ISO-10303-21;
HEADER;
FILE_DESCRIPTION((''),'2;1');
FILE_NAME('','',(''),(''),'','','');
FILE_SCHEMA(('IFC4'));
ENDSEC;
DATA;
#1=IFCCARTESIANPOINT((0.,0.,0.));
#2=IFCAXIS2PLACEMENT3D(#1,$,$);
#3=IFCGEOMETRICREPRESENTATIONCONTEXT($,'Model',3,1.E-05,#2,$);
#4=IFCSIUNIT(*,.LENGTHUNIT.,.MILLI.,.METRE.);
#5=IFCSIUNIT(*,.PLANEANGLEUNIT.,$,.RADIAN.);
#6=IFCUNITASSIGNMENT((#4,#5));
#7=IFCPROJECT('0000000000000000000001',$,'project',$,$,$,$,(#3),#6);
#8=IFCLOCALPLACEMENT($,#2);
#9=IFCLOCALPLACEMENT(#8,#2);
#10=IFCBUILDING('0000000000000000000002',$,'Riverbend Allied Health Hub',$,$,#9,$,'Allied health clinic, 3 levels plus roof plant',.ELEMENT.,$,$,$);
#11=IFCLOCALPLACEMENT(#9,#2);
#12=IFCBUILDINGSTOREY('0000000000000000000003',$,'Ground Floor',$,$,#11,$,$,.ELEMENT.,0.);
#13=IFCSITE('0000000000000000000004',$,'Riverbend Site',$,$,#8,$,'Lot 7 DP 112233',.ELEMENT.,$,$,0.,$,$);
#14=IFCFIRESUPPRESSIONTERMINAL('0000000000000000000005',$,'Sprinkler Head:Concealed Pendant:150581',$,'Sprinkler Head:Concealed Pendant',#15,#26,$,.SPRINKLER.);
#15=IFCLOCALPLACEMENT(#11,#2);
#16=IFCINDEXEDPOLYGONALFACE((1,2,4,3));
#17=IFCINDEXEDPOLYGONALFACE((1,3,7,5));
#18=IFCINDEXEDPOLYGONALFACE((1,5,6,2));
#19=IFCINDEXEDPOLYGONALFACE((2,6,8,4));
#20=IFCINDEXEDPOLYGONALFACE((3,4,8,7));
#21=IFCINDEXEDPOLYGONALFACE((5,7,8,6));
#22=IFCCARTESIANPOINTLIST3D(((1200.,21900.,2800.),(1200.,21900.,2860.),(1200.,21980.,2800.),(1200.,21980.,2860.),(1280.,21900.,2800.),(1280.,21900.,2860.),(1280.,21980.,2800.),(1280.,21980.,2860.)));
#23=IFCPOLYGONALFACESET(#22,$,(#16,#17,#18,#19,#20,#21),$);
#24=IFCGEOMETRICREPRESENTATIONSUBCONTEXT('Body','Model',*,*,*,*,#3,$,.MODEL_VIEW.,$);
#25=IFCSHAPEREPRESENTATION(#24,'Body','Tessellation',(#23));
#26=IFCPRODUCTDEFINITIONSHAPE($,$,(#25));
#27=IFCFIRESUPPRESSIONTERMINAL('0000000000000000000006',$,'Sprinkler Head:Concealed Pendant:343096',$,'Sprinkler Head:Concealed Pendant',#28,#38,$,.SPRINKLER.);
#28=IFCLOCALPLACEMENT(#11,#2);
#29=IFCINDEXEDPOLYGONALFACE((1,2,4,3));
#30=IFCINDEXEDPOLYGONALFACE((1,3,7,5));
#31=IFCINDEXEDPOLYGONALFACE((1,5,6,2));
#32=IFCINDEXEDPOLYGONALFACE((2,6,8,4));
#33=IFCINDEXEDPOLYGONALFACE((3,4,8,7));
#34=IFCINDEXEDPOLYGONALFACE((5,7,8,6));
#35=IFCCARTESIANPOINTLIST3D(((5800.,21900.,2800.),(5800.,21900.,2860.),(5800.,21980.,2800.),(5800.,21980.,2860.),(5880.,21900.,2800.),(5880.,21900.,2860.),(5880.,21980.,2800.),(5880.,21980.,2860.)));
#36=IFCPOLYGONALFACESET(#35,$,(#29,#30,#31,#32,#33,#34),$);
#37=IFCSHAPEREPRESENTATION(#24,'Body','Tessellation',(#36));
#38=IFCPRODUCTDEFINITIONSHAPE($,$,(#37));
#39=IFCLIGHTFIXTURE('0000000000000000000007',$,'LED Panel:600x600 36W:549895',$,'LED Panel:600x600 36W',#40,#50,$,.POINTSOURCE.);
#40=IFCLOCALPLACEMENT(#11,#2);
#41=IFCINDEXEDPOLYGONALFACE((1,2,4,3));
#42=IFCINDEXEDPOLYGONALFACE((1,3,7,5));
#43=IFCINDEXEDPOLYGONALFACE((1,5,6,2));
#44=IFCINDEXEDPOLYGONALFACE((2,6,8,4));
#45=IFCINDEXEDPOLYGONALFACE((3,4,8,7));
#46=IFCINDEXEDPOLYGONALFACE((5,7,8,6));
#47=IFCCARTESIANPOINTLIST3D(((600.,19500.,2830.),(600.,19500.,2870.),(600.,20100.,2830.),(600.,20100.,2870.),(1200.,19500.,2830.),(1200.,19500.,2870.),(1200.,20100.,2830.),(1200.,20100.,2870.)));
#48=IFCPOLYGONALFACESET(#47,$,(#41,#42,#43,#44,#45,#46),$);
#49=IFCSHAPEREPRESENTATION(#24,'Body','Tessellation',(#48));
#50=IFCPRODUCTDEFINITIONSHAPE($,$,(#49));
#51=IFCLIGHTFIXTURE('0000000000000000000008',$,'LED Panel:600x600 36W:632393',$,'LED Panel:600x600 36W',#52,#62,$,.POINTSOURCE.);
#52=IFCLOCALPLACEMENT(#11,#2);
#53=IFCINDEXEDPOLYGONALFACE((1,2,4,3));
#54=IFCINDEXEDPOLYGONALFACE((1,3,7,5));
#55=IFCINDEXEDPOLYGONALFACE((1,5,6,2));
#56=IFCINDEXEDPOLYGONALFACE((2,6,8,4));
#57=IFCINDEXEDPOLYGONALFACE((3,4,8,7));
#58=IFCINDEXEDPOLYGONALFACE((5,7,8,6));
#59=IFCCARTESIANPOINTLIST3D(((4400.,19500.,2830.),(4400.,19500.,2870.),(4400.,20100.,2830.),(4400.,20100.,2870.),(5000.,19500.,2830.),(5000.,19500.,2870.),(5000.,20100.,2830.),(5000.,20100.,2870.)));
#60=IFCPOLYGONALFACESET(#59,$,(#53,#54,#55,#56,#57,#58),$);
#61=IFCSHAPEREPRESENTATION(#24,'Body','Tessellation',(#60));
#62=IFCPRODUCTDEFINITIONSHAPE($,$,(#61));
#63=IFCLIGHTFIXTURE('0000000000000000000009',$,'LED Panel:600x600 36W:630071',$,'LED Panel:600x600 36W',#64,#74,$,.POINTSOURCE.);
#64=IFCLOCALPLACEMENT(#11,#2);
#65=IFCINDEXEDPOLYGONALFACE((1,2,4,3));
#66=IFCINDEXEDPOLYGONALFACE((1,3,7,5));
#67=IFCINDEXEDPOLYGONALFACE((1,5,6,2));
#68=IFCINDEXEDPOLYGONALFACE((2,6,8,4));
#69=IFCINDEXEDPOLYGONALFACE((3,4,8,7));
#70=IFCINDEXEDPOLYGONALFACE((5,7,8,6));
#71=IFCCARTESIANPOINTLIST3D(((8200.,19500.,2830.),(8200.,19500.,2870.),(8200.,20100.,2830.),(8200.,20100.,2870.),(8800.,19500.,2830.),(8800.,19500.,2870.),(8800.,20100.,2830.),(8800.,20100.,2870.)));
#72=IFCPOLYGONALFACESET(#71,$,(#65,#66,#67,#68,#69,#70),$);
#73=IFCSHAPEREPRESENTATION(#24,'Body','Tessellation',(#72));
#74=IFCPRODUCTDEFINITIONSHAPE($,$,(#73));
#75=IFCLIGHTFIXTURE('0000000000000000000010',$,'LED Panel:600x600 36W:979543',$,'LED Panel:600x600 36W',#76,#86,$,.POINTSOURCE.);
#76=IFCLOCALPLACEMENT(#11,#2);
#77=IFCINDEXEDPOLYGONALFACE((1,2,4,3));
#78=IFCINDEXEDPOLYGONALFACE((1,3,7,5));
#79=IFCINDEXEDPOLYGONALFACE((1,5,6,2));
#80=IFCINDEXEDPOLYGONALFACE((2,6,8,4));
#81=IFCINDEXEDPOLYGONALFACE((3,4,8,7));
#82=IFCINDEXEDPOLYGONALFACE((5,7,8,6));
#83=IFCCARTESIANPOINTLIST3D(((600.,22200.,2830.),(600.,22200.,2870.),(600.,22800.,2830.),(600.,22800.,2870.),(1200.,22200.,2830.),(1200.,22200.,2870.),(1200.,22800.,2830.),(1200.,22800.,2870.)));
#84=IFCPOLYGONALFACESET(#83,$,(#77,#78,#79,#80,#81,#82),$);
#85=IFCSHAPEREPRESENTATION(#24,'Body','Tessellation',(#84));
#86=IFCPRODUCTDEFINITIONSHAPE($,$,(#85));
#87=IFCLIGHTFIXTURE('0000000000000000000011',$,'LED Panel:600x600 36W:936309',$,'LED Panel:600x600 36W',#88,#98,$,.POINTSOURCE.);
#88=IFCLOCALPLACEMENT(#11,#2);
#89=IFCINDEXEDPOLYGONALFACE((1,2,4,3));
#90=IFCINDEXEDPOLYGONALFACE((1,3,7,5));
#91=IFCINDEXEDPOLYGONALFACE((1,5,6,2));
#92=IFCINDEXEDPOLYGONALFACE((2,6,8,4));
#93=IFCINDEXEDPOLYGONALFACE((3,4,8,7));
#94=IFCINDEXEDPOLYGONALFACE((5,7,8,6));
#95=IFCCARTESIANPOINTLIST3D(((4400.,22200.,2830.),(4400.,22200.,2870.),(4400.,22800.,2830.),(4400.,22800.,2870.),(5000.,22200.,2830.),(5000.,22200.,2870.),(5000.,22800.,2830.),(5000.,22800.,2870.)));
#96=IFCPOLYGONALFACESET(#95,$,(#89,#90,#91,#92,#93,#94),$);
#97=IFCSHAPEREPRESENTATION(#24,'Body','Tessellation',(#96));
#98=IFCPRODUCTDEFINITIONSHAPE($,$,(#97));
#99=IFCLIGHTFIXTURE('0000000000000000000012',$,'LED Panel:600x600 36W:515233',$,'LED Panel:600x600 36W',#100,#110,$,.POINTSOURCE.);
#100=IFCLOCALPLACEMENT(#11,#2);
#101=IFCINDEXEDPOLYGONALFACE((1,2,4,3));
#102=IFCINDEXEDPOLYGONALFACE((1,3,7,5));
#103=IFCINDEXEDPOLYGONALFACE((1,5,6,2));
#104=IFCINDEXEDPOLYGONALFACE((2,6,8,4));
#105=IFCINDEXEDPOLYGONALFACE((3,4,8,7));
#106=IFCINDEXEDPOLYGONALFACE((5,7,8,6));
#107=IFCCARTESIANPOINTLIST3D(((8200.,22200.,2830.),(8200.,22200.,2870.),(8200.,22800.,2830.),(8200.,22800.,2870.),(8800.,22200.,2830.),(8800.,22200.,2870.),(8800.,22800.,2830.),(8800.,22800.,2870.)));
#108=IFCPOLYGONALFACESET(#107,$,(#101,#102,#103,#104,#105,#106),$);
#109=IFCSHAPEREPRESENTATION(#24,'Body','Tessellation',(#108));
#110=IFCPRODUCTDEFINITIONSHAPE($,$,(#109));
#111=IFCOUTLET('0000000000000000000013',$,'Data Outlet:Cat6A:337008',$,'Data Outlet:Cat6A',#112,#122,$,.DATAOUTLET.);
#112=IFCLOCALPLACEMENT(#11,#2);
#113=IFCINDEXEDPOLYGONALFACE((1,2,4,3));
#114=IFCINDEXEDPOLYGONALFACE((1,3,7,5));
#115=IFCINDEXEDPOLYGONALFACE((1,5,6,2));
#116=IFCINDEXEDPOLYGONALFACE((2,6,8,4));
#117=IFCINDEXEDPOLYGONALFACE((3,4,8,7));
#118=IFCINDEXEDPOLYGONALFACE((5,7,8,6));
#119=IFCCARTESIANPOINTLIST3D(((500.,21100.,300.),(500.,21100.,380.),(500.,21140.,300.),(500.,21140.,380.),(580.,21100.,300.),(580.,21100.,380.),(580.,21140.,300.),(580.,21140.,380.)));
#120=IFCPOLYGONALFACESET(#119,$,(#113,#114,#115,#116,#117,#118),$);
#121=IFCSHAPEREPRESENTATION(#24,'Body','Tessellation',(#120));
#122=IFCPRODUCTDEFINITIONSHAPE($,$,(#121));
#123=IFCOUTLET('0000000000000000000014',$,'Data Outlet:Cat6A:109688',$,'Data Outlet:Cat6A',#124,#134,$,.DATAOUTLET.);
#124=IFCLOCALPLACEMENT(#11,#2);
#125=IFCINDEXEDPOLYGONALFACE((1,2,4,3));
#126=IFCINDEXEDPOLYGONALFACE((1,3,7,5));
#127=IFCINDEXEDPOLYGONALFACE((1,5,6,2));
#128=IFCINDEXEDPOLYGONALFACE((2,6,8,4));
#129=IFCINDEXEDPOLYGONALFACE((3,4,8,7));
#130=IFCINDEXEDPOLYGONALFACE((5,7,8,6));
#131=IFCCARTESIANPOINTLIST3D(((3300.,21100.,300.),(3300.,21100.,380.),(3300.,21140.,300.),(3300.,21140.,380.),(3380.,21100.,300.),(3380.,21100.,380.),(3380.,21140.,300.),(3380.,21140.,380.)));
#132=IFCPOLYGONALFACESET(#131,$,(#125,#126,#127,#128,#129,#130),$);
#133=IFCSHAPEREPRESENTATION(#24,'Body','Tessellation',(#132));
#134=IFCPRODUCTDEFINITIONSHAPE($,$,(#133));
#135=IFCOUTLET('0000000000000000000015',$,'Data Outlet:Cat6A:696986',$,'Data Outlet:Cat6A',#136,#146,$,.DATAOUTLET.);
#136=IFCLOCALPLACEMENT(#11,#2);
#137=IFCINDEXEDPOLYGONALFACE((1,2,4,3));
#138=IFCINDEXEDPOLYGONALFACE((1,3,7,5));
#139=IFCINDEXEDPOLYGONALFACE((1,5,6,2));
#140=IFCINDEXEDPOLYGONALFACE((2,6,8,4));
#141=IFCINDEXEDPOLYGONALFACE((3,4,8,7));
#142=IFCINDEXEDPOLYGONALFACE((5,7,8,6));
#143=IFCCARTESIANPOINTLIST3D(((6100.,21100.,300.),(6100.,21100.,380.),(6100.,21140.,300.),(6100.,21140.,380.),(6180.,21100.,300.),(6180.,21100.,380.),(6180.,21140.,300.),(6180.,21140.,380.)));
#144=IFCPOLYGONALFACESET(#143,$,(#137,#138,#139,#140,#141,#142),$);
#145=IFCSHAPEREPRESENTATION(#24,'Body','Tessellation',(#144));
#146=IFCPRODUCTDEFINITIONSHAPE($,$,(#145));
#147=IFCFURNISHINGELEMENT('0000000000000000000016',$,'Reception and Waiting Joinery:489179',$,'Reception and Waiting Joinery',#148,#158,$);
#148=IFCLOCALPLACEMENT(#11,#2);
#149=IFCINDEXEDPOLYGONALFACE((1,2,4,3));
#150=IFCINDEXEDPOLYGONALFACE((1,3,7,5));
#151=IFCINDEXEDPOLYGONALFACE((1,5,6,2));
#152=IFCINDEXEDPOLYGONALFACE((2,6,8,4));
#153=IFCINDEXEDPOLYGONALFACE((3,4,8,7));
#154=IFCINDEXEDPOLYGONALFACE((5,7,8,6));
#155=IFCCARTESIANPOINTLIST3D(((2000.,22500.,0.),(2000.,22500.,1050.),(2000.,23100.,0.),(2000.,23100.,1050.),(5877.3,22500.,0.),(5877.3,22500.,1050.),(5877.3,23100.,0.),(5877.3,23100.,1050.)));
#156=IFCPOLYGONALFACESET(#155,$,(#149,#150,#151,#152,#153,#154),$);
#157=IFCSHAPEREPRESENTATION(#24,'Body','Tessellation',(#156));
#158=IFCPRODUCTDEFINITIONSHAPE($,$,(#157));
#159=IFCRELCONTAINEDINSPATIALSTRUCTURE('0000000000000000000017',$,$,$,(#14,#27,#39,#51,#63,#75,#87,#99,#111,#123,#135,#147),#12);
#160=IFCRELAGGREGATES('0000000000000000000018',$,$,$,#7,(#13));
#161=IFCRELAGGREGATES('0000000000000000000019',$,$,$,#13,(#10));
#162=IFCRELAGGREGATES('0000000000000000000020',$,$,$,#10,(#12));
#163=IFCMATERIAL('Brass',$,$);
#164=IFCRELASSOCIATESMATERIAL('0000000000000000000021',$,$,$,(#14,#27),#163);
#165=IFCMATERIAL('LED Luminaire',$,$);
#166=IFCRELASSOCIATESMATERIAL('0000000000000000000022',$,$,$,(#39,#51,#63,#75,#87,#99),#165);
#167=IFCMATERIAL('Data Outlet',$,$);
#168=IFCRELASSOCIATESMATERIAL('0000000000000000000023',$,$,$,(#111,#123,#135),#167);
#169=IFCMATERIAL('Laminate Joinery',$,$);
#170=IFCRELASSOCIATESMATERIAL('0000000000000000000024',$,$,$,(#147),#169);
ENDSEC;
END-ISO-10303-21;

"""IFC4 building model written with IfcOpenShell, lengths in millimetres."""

from ifc_helpers import new_model, si_unit, frame, frame_2d, origin, place, context, subcontext, project, spatial, rectangle, extrude, material, element, save


model = new_model("IFC4")

# Units and contexts
model_context = context("Model", 3, precision=1e-05, world=origin())
body_context = subcontext(model_context, "Body", "Model", "MODEL_VIEW")
ifc_project = project(units=[si_unit("LENGTHUNIT", "METRE", prefix="MILLI"), si_unit("PLANEANGLEUNIT", "RADIAN")], contexts=[model_context])

# Site, building, storey
site_placement = place(None, origin())
site = spatial("IfcSite", under=ifc_project, at=site_placement, Name="Riverbend Site", LongName="Lot 7 DP 112233", CompositionType="ELEMENT", RefElevation=0.0)
building_placement = place(site_placement, origin())
building = spatial("IfcBuilding", under=site, at=building_placement, Name="Riverbend Allied Health Hub", LongName="Allied health clinic, 3 levels plus roof plant", CompositionType="ELEMENT")
storey_placement = place(building_placement, origin())
storey = spatial("IfcBuildingStorey", under=building, at=storey_placement, Name="Ground Floor", CompositionType="ELEMENT", Elevation=0.0)

# Fire suppression terminals
ifc_material_1 = material(Name="Brass")
for number, where, name in (
    (1, (1200.0, 21900.0, 2800.0), "Sprinkler Head:Concealed Pendant:150581"),
    (2, (5800.0, 21900.0, 2800.0), "Sprinkler Head:Concealed Pendant:343096"),
):
    element("IfcFireSuppressionTerminal", number, at=place(storey_placement, frame(where)), inside=storey, material=ifc_material_1, Name=name, ObjectType="Sprinkler Head:Concealed Pendant", PredefinedType="SPRINKLER", context=body_context, shape_type="SweptSolid", body=[
        extrude(rectangle(XDim=80.0, YDim=80.0, at=frame_2d((40.0, 40.0))), origin(), (0.0, 0.0, 1.0), 60.0),
    ])

# Light fixtures
ifc_material_2 = material(Name="LED Luminaire")
for number, where, name in (
    (3, (600.0, 19500.0, 2830.0), "LED Panel:600x600 36W:549895"),
    (4, (4400.0, 19500.0, 2830.0), "LED Panel:600x600 36W:632393"),
    (5, (8200.0, 19500.0, 2830.0), "LED Panel:600x600 36W:630071"),
    (6, (600.0, 22200.0, 2830.0), "LED Panel:600x600 36W:979543"),
    (7, (4400.0, 22200.0, 2830.0), "LED Panel:600x600 36W:936309"),
    (8, (8200.0, 22200.0, 2830.0), "LED Panel:600x600 36W:515233"),
):
    element("IfcLightFixture", number, at=place(storey_placement, frame(where)), inside=storey, material=ifc_material_2, Name=name, ObjectType="LED Panel:600x600 36W", PredefinedType="POINTSOURCE", context=body_context, shape_type="SweptSolid", body=[
        extrude(rectangle(XDim=600.0, YDim=600.0, at=frame_2d((300.0, 300.0))), origin(), (0.0, 0.0, 1.0), 40.0),
    ])

# Outlets
ifc_material_3 = material(Name="Data Outlet")
for number, where, name in (
    (9, (500.0, 21100.0, 300.0), "Data Outlet:Cat6A:337008"),
    (10, (3300.0, 21100.0, 300.0), "Data Outlet:Cat6A:109688"),
    (11, (6100.0, 21100.0, 300.0), "Data Outlet:Cat6A:696986"),
):
    element("IfcOutlet", number, at=place(storey_placement, frame(where)), inside=storey, material=ifc_material_3, Name=name, ObjectType="Data Outlet:Cat6A", PredefinedType="DATAOUTLET", context=body_context, shape_type="SweptSolid", body=[
        extrude(rectangle(XDim=80.0, YDim=40.0, at=frame_2d((40.0, 20.0))), origin(), (0.0, 0.0, 1.0), 80.0),
    ])

# Furnishing element
ifc_material_4 = material(Name="Laminate Joinery")
furnishing_placement = place(storey_placement, frame((2000.0, 22500.0, 0.0)))
element("IfcFurnishingElement", 12, at=furnishing_placement, inside=storey, material=ifc_material_4, Name="Reception and Waiting Joinery:489179", ObjectType="Reception and Waiting Joinery", context=body_context, shape_type="SweptSolid", body=[
    extrude(rectangle(XDim=3877.3, YDim=600.0, at=frame_2d((1938.7, 300.0))), origin(), (0.0, 0.0, 1.0), 1050.0),
])

save(model, "model.ifc")
